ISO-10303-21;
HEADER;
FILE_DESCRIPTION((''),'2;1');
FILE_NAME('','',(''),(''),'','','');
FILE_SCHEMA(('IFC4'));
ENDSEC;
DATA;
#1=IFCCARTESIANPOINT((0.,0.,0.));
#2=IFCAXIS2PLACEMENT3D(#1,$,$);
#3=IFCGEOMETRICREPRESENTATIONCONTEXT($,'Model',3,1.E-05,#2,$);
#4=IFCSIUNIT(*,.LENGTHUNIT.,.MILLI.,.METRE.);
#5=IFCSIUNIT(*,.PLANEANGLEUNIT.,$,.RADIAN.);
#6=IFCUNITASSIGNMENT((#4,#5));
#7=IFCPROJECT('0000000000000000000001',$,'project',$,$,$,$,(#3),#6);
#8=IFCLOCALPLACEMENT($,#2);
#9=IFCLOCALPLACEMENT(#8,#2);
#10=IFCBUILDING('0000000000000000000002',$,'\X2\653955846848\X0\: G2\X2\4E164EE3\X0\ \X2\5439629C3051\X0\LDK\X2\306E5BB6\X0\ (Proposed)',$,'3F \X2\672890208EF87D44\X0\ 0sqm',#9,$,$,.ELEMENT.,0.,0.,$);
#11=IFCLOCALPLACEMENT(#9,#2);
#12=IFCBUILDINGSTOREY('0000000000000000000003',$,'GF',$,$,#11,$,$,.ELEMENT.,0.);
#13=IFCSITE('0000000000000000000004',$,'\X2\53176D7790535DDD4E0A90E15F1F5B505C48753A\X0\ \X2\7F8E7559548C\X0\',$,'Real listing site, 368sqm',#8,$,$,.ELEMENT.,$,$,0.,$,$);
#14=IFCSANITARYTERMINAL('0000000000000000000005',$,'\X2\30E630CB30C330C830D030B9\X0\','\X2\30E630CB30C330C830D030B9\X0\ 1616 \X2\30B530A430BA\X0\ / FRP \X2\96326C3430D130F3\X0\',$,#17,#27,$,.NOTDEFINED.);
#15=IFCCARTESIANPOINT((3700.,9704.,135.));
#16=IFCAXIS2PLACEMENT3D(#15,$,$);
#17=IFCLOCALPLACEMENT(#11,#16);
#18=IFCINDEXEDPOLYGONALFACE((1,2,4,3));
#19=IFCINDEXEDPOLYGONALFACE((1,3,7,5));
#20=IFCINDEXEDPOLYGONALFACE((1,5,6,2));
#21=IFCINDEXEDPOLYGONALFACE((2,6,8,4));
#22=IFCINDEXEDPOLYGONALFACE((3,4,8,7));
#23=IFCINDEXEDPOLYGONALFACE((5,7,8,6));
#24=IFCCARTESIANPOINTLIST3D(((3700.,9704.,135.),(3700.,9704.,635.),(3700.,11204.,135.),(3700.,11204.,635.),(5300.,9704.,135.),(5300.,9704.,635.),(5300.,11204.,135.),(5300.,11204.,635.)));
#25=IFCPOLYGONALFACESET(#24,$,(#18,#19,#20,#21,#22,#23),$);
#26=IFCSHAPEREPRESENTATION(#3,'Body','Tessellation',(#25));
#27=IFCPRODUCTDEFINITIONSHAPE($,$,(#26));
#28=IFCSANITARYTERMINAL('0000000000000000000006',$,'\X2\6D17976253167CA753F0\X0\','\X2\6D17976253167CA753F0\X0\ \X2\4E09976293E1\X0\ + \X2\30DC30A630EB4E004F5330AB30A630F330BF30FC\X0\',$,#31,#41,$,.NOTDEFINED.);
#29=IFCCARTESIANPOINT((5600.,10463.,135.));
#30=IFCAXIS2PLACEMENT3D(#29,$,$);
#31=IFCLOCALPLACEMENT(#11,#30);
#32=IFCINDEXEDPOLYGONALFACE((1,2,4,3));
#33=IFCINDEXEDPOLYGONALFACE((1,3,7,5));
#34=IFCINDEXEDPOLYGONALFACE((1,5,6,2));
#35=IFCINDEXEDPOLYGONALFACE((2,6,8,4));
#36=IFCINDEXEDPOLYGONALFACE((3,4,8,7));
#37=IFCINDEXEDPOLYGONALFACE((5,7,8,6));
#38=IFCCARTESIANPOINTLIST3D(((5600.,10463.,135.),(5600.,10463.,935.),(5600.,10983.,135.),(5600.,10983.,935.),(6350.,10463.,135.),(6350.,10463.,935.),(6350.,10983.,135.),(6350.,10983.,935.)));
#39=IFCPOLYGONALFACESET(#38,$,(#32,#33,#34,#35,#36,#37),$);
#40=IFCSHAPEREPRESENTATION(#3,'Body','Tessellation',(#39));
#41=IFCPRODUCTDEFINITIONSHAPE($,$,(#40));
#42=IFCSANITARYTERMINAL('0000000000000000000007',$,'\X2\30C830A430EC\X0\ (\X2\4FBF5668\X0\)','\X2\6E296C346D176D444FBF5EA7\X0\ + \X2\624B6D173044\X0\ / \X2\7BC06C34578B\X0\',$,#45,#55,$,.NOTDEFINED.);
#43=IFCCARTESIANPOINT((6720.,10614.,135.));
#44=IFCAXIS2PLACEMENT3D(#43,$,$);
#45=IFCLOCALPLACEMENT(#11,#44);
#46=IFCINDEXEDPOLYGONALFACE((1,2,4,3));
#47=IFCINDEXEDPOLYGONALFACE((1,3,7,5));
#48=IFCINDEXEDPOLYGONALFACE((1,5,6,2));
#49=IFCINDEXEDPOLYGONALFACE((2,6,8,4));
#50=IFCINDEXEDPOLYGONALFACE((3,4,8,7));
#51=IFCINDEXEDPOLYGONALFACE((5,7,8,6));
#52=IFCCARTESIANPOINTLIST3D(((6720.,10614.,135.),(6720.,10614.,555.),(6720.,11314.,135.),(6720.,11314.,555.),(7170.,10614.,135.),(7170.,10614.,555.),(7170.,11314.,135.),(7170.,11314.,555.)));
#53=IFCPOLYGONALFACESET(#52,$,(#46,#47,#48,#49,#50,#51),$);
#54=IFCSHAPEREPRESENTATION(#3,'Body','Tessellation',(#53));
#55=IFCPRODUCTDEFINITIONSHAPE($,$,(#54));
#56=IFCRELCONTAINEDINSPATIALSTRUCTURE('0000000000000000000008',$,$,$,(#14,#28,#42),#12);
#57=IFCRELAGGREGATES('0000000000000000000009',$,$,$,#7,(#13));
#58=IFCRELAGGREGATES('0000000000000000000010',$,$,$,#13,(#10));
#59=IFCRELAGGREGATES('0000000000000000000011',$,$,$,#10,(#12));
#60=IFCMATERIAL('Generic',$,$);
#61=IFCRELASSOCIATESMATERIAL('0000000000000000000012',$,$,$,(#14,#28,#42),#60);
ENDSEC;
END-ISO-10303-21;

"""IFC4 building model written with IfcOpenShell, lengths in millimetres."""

from ifc_helpers import new_model, si_unit, frame, frame_2d, origin, place, context, project, spatial, rectangle, extrude, material, element, save


model = new_model("IFC4")

# Units and contexts
model_context = context("Model", 3, precision=1e-05, world=origin())
ifc_project = project(units=[si_unit("LENGTHUNIT", "METRE", prefix="MILLI"), si_unit("PLANEANGLEUNIT", "RADIAN")], contexts=[model_context])

# Site, building, storey
site_placement = place(None, origin())
site = spatial("IfcSite", under=ifc_project, at=site_placement, Name="北海道川上郡弟子屈町 美留和", ObjectType="Real listing site, 368sqm", CompositionType="ELEMENT", RefElevation=0.0)
building_placement = place(site_placement, origin())
building = spatial("IfcBuilding", under=site, at=building_placement, Name="改善案: G2世代 吹抜けLDKの家 (Proposed)", ObjectType="3F 木造軸組 0sqm", CompositionType="ELEMENT", ElevationOfRefHeight=0.0, ElevationOfTerrain=0.0)
storey_placement = place(building_placement, origin())
storey = spatial("IfcBuildingStorey", under=building, at=storey_placement, Name="GF", CompositionType="ELEMENT", Elevation=0.0)

# Shared definitions
ifc_material_1 = material(Name="Generic")

# Sanitary terminals
sanitary_terminal_1_placement = place(storey_placement, frame((3700.0, 9704.0, 135.0)))
element("IfcSanitaryTerminal", 1, at=sanitary_terminal_1_placement, inside=storey, material=ifc_material_1, Name="ユニットバス", Description="ユニットバス 1616 サイズ / FRP 防水パン", PredefinedType="NOTDEFINED", context=model_context, shape_type="SweptSolid", body=[
    extrude(rectangle(XDim=1600.0, YDim=1500.0, at=frame_2d((800.0, 750.0))), frame((3700.0, 9704.0, 135.0)), (0.0, 0.0, 1.0), 500.0),
])
sanitary_terminal_2_placement = place(storey_placement, frame((5600.0, 10463.0, 135.0)))
element("IfcSanitaryTerminal", 2, at=sanitary_terminal_2_placement, inside=storey, material=ifc_material_1, Name="洗面化粧台", Description="洗面化粧台 三面鏡 + ボウル一体カウンター", PredefinedType="NOTDEFINED", context=model_context, shape_type="SweptSolid", body=[
    extrude(rectangle(XDim=750.0, YDim=520.0, at=frame_2d((375.0, 260.0))), frame((5600.0, 10463.0, 135.0)), (0.0, 0.0, 1.0), 800.0),
])
sanitary_terminal_3_placement = place(storey_placement, frame((6720.0, 10614.0, 135.0)))
element("IfcSanitaryTerminal", 3, at=sanitary_terminal_3_placement, inside=storey, material=ifc_material_1, Name="トイレ (便器)", Description="温水洗浄便座 + 手洗い / 節水型", PredefinedType="NOTDEFINED", context=model_context, shape_type="SweptSolid", body=[
    extrude(rectangle(XDim=450.0, YDim=700.0, at=frame_2d((225.0, 350.0))), frame((6720.0, 10614.0, 135.0)), (0.0, 0.0, 1.0), 420.0),
])

save(model, "model.ifc")
